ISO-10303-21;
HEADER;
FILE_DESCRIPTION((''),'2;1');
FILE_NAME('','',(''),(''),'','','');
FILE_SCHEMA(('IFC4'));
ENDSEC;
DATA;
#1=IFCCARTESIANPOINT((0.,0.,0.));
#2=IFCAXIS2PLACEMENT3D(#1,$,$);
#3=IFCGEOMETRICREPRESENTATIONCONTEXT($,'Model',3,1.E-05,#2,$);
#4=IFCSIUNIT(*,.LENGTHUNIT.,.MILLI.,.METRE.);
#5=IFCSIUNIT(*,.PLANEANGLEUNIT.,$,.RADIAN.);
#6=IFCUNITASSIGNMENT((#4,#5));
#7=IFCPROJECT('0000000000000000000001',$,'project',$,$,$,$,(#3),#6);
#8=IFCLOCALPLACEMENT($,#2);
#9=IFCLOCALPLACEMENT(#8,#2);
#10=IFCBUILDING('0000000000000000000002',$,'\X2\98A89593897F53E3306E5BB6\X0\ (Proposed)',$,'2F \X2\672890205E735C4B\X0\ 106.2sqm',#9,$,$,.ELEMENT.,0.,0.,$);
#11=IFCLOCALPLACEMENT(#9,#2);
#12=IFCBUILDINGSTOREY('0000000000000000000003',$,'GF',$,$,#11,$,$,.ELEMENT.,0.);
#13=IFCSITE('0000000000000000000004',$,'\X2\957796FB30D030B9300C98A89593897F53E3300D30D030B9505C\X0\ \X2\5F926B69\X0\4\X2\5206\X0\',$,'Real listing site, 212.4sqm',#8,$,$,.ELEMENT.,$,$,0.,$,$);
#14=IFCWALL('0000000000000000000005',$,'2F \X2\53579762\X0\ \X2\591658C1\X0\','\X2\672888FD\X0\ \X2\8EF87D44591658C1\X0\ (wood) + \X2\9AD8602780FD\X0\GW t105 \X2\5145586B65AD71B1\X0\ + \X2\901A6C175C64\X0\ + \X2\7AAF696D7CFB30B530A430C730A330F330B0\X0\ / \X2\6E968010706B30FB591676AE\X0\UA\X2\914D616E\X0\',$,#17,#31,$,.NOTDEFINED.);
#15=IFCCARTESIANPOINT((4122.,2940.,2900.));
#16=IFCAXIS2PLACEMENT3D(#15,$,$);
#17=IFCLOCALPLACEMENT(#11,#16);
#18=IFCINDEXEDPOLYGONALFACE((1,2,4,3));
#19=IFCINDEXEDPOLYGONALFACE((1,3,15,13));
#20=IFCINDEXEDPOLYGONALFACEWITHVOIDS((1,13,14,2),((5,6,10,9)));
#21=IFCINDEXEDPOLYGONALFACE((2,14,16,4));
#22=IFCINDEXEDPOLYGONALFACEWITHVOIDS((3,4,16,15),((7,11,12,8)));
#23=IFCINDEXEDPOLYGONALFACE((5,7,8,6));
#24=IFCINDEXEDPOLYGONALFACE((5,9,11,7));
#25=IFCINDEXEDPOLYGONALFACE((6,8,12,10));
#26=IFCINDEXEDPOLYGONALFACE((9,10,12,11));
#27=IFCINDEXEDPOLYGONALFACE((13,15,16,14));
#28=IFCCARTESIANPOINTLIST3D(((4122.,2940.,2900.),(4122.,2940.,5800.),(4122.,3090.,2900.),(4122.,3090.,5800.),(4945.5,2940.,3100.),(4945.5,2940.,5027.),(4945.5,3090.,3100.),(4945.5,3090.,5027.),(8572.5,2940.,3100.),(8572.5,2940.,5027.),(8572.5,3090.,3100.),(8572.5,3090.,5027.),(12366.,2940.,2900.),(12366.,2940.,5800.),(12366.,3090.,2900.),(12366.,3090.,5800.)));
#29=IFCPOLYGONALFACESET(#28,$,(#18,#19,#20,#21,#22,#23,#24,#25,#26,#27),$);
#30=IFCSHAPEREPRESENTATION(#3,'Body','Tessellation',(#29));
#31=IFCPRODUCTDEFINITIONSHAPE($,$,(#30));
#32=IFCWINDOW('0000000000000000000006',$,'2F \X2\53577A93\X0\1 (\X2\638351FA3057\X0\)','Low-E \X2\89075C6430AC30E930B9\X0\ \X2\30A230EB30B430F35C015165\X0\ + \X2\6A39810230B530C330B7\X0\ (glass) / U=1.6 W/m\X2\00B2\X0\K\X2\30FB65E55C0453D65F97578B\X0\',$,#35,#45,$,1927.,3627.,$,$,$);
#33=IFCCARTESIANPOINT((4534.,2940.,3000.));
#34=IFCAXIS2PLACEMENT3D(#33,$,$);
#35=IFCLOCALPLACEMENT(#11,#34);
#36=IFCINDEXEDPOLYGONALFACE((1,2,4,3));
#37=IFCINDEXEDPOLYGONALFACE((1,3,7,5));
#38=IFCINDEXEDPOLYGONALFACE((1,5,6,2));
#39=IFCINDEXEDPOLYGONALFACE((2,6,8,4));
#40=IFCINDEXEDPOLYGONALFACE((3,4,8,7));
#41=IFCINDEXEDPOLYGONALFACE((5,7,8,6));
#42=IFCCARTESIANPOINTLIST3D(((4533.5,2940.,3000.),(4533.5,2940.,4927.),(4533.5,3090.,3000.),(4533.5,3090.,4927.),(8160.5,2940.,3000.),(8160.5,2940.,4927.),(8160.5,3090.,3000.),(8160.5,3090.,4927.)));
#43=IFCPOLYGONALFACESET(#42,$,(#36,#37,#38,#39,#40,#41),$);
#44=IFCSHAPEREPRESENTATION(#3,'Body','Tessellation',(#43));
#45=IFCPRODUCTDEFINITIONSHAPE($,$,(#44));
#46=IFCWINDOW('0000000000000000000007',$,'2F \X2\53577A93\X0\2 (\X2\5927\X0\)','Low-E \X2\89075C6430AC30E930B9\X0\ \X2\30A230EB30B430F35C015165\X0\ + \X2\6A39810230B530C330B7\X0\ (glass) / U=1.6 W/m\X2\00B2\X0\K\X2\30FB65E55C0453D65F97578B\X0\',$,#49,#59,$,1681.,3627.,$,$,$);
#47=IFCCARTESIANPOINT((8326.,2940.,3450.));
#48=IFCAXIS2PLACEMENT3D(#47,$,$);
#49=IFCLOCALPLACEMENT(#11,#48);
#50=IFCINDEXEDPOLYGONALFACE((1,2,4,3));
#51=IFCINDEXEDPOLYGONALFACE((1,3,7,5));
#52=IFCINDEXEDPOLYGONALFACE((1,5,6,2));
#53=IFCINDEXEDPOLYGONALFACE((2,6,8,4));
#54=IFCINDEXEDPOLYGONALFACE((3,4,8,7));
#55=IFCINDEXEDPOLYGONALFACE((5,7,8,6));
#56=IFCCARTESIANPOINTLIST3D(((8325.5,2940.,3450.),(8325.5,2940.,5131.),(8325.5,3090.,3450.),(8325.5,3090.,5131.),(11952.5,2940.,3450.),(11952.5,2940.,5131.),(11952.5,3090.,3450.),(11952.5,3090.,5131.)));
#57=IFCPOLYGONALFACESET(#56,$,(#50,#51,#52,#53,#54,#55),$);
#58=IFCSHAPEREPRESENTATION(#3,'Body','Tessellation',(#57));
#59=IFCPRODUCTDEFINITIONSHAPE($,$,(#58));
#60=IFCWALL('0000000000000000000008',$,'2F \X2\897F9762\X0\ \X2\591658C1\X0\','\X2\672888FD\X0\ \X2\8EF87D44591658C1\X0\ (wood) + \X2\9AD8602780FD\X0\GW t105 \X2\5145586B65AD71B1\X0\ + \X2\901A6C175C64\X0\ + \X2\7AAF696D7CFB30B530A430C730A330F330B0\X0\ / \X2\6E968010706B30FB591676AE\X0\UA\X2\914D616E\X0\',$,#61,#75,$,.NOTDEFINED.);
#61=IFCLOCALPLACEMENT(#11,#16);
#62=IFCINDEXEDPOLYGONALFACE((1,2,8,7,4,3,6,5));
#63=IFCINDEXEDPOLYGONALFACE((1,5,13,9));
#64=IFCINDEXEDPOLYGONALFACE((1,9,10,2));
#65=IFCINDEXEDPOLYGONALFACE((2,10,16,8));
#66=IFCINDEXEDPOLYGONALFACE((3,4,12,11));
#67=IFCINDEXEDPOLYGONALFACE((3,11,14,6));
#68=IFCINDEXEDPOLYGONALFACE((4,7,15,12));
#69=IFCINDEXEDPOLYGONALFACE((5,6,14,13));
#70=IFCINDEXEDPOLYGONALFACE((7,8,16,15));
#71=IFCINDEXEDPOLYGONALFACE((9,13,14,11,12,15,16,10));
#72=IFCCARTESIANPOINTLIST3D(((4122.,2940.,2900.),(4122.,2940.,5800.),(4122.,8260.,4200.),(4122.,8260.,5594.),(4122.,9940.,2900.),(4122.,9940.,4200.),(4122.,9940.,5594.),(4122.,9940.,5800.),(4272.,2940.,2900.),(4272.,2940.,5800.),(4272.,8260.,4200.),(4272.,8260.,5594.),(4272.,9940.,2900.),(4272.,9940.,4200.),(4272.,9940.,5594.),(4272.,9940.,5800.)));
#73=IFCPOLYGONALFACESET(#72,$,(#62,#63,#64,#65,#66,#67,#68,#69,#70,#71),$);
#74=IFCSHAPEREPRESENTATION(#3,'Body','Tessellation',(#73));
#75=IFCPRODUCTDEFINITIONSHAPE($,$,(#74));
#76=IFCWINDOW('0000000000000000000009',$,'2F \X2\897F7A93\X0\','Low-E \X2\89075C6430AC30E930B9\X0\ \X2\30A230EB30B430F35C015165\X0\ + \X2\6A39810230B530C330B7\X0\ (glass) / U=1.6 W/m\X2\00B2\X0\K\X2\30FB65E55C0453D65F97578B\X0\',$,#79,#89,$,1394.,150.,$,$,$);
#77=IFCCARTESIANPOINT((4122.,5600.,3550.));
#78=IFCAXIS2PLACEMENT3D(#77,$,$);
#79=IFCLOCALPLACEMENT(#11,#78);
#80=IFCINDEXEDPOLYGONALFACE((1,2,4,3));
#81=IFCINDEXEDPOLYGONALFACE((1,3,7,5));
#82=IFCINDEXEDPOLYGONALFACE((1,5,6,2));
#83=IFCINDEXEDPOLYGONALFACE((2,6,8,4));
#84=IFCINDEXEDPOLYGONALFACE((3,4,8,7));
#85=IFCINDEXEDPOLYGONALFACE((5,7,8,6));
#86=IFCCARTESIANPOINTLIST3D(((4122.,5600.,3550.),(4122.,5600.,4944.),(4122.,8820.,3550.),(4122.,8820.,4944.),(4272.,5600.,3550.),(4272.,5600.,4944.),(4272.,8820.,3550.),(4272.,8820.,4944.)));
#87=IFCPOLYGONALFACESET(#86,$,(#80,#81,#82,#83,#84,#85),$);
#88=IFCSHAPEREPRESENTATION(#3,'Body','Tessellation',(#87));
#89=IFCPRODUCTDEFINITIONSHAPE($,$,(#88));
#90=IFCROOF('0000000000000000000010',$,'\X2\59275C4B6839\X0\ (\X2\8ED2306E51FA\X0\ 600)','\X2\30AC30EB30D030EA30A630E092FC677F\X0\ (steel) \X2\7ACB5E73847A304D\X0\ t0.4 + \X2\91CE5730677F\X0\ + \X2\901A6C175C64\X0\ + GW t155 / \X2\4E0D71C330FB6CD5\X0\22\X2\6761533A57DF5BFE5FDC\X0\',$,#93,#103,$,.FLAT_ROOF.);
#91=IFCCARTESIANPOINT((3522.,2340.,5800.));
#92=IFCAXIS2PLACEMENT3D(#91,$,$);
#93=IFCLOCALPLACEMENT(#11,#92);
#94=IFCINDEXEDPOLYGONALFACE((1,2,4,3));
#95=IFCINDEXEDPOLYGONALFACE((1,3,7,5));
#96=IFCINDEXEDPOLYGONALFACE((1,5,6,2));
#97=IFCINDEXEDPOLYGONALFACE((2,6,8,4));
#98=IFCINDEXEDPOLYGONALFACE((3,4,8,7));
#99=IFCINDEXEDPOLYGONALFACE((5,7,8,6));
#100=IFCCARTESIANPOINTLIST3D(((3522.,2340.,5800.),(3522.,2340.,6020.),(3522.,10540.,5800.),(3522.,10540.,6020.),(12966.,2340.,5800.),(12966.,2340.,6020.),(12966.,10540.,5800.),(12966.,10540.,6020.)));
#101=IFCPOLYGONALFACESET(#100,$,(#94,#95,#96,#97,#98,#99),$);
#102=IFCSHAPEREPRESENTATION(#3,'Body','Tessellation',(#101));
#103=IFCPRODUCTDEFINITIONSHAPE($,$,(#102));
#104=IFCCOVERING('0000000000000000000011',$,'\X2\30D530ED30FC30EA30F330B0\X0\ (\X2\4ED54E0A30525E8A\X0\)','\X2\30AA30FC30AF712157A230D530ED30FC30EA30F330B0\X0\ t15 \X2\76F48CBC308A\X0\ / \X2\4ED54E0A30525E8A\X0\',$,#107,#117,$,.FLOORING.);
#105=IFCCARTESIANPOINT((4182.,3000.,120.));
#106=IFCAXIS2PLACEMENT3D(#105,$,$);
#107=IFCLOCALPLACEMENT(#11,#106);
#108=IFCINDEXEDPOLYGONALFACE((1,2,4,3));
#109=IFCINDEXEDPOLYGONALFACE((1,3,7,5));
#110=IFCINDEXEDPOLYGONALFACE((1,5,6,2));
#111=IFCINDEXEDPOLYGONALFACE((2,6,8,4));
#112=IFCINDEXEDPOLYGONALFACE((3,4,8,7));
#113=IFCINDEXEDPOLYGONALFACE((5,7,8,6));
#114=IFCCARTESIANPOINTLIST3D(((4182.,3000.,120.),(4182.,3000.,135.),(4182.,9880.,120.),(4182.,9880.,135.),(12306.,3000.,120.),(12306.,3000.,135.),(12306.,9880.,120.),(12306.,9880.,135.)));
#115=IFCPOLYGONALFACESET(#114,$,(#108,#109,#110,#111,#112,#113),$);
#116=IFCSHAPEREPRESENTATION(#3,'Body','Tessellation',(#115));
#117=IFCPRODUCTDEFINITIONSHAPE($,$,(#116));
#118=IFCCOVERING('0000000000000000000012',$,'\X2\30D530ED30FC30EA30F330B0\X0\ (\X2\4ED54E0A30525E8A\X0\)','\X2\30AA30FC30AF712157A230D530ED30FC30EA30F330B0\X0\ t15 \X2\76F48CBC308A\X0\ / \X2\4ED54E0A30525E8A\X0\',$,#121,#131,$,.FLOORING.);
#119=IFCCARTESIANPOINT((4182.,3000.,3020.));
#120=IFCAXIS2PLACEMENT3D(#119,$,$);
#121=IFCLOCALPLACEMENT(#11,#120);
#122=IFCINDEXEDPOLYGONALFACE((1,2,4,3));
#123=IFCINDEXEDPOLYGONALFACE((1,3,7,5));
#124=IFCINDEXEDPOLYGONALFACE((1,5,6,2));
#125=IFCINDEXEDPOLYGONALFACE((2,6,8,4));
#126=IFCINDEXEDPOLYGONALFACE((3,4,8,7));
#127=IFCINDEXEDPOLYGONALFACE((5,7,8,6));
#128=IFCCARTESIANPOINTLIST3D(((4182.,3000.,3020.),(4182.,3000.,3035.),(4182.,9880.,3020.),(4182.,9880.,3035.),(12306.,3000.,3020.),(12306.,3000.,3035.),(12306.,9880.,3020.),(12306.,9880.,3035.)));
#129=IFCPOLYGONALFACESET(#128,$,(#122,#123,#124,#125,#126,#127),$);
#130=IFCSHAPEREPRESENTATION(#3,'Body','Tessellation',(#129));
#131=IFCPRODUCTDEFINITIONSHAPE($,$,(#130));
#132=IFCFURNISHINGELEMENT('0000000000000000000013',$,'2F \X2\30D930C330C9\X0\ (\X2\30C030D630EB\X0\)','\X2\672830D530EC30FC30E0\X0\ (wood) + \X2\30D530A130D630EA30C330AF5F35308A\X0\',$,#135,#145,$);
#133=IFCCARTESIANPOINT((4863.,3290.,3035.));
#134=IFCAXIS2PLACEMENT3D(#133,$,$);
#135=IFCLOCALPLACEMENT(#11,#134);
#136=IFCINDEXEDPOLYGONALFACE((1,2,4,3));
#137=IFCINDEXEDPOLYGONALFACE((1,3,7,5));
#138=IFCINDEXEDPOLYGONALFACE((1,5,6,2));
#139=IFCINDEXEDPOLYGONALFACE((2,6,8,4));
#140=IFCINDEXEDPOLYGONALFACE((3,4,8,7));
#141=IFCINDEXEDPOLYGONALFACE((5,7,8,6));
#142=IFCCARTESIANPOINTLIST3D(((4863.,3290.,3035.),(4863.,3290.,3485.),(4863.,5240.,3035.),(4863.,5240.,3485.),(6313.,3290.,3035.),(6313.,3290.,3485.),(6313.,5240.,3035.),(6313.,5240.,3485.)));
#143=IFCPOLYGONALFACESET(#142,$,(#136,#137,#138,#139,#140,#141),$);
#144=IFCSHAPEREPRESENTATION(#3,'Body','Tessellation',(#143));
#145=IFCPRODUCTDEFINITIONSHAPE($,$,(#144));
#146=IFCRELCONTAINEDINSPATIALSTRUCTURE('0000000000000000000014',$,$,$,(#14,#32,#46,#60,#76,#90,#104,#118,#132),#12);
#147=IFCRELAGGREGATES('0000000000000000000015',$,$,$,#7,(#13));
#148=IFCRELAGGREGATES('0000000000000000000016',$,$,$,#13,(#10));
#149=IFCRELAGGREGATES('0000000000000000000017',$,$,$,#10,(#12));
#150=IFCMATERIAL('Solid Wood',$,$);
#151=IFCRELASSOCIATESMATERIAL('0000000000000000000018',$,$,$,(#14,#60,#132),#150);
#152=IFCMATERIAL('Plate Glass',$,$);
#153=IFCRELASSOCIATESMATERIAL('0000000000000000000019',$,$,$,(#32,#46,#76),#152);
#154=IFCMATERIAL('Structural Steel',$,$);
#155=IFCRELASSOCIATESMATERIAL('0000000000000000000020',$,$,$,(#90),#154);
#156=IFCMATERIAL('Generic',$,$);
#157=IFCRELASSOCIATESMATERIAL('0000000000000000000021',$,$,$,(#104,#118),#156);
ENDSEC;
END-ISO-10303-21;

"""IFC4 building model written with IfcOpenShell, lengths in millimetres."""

from ifc_helpers import new_model, si_unit, frame, frame_2d, origin, place, context, project, spatial, rectangle, extrude, material, element, fill, save


model = new_model("IFC4")

# Units and contexts
model_context = context("Model", 3, precision=1e-05, world=origin())
ifc_project = project(units=[si_unit("LENGTHUNIT", "METRE", prefix="MILLI"), si_unit("PLANEANGLEUNIT", "RADIAN")], contexts=[model_context])

# Site, building, storey
site_placement = place(None, origin())
site = spatial("IfcSite", under=ifc_project, at=site_placement, Name="長電バス「風間西口」バス停 徒歩4分", ObjectType="Real listing site, 212.4sqm", CompositionType="ELEMENT", RefElevation=0.0)
building_placement = place(site_placement, origin())
building = spatial("IfcBuilding", under=site, at=building_placement, Name="風間西口の家 (Proposed)", ObjectType="2F 木造平屋 106.2sqm", CompositionType="ELEMENT", ElevationOfRefHeight=0.0, ElevationOfTerrain=0.0)
storey_placement = place(building_placement, origin())
storey = spatial("IfcBuildingStorey", under=building, at=storey_placement, Name="GF", CompositionType="ELEMENT", Elevation=0.0)

# Shared definitions
ifc_material_1 = material(Name="Solid Wood")

# Shared definitions
ifc_material_2 = material(Name="Plate Glass")

# Wall, openings, windows
wall_1_placement = place(storey_placement, frame((4122.0, 2940.0, 2900.0)))
wall_1 = element("IfcWall", 1, at=wall_1_placement, inside=storey, material=ifc_material_1, Name="2F 南面 外壁", Description="木製 軸組外壁 (wood) + 高性能GW t105 充填断熱 + 通気層 + 窯業系サイディング / 準耐火・外皮UA配慮", PredefinedType="NOTDEFINED", context=model_context, shape_type="SweptSolid", body=[
    extrude(rectangle(XDim=8244.0, YDim=150.0, at=frame_2d((4122.0, 75.0))), frame((4122.0, 2940.0, 2900.0)), (0.0, 0.0, 1.0), 2900.0),
])
opening_1_placement = place(storey_placement, frame((4534.0, 2940.0, 3000.0)))
opening_1 = element("IfcOpeningElement", 2, at=opening_1_placement, cuts=wall_1, PredefinedType="NOTDEFINED", context=model_context, shape_type="SweptSolid", body=[
    extrude(rectangle(XDim=3627.0, YDim=150.0, at=frame_2d((1813.0, 75.0))), frame((4534.0, 2940.0, 3000.0)), (0.0, 0.0, 1.0), 1927.0),
])
opening_2_placement = place(storey_placement, frame((8326.0, 2940.0, 3450.0)))
opening_2 = element("IfcOpeningElement", 3, at=opening_2_placement, cuts=wall_1, PredefinedType="NOTDEFINED", context=model_context, shape_type="SweptSolid", body=[
    extrude(rectangle(XDim=3627.0, YDim=150.0, at=frame_2d((1813.0, 75.0))), frame((8326.0, 2940.0, 3450.0)), (0.0, 0.0, 1.0), 1681.0),
])
window_1_placement = place(storey_placement, frame((4534.0, 2940.0, 3000.0)))
window_1 = element("IfcWindow", 4, at=window_1_placement, inside=storey, material=ifc_material_2, Name="2F 南窓1 (掃出し)", Description="Low-E 複層ガラス アルゴン封入 + 樹脂サッシ (glass) / U=1.6 W/m²K・日射取得型", OverallHeight=1927.0, OverallWidth=3627.0, context=model_context, shape_type="SweptSolid", body=[
    extrude(rectangle(XDim=3627.0, YDim=150.0, at=frame_2d((1813.0, 75.0))), frame((4534.0, 2940.0, 3000.0)), (0.0, 0.0, 1.0), 1927.0),
])
fill(opening_1, window_1)
window_2_placement = place(storey_placement, frame((8326.0, 2940.0, 3450.0)))
window_2 = element("IfcWindow", 5, at=window_2_placement, inside=storey, material=ifc_material_2, Name="2F 南窓2 (大)", Description="Low-E 複層ガラス アルゴン封入 + 樹脂サッシ (glass) / U=1.6 W/m²K・日射取得型", OverallHeight=1681.0, OverallWidth=3627.0, context=model_context, shape_type="SweptSolid", body=[
    extrude(rectangle(XDim=3627.0, YDim=150.0, at=frame_2d((1813.0, 75.0))), frame((8326.0, 2940.0, 3450.0)), (0.0, 0.0, 1.0), 1681.0),
])
fill(opening_2, window_2)

# Wall, opening, window
wall_2_placement = place(storey_placement, frame((4122.0, 2940.0, 2900.0)))
wall_2 = element("IfcWall", 6, at=wall_2_placement, inside=storey, material=ifc_material_1, Name="2F 西面 外壁", Description="木製 軸組外壁 (wood) + 高性能GW t105 充填断熱 + 通気層 + 窯業系サイディング / 準耐火・外皮UA配慮", PredefinedType="NOTDEFINED", context=model_context, shape_type="SweptSolid", body=[
    extrude(rectangle(XDim=150.0, YDim=7000.0, at=frame_2d((75.0, 3500.0))), frame((4122.0, 2940.0, 2900.0)), (0.0, 0.0, 1.0), 2900.0),
])
opening_3_placement = place(storey_placement, frame((4122.0, 5600.0, 3550.0)))
opening_3 = element("IfcOpeningElement", 7, at=opening_3_placement, cuts=wall_2, PredefinedType="NOTDEFINED", context=model_context, shape_type="SweptSolid", body=[
    extrude(rectangle(XDim=150.0, YDim=3220.0, at=frame_2d((75.0, 1610.0))), frame((4122.0, 5600.0, 3550.0)), (0.0, 0.0, 1.0), 1394.0),
])
window_3_placement = place(storey_placement, frame((4122.0, 5600.0, 3550.0)))
window_3 = element("IfcWindow", 8, at=window_3_placement, inside=storey, material=ifc_material_2, Name="2F 西窓", Description="Low-E 複層ガラス アルゴン封入 + 樹脂サッシ (glass) / U=1.6 W/m²K・日射取得型", OverallHeight=1394.0, OverallWidth=150.0, context=model_context, shape_type="SweptSolid", body=[
    extrude(rectangle(XDim=150.0, YDim=3220.0, at=frame_2d((75.0, 1610.0))), frame((4122.0, 5600.0, 3550.0)), (0.0, 0.0, 1.0), 1394.0),
])
fill(opening_3, window_3)

# Roof
ifc_material_3 = material(Name="Structural Steel")
roof_placement = place(storey_placement, frame((3522.0, 2340.0, 5800.0)))
element("IfcRoof", 9, at=roof_placement, inside=storey, material=ifc_material_3, Name="大屋根 (軒の出 600)", Description="ガルバリウム鋼板 (steel) 立平葺き t0.4 + 野地板 + 通気層 + GW t155 / 不燃・法22条区域対応", PredefinedType="FLAT_ROOF", context=model_context, shape_type="SweptSolid", body=[
    extrude(rectangle(XDim=9444.0, YDim=8200.0, at=frame_2d((4722.0, 4100.0))), frame((3522.0, 2340.0, 5800.0)), (0.0, 0.0, 1.0), 220.0),
])

# Coverings
ifc_material_4 = material(Name="Generic")
covering_1_placement = place(storey_placement, frame((4182.0, 3000.0, 120.0)))
element("IfcCovering", 10, at=covering_1_placement, inside=storey, material=ifc_material_4, Name="フローリング (仕上げ床)", Description="オーク無垢フローリング t15 直貼り / 仕上げ床", PredefinedType="FLOORING", context=model_context, shape_type="SweptSolid", body=[
    extrude(rectangle(XDim=8124.0, YDim=6880.0, at=frame_2d((4062.0, 3440.0))), frame((4182.0, 3000.0, 120.0)), (0.0, 0.0, 1.0), 15.0),
])
covering_2_placement = place(storey_placement, frame((4182.0, 3000.0, 3020.0)))
element("IfcCovering", 11, at=covering_2_placement, inside=storey, material=ifc_material_4, Name="フローリング (仕上げ床)", Description="オーク無垢フローリング t15 直貼り / 仕上げ床", PredefinedType="FLOORING", context=model_context, shape_type="SweptSolid", body=[
    extrude(rectangle(XDim=8124.0, YDim=6880.0, at=frame_2d((4062.0, 3440.0))), frame((4182.0, 3000.0, 3020.0)), (0.0, 0.0, 1.0), 15.0),
])

# Furnishing element
furnishing_placement = place(storey_placement, frame((4863.0, 3290.0, 3035.0)))
element("IfcFurnishingElement", 12, at=furnishing_placement, inside=storey, material=ifc_material_1, Name="2F ベッド (ダブル)", Description="木フレーム (wood) + ファブリック張り", context=model_context, shape_type="SweptSolid", body=[
    extrude(rectangle(XDim=1450.0, YDim=1950.0, at=frame_2d((725.0, 975.0))), frame((4863.0, 3290.0, 3035.0)), (0.0, 0.0, 1.0), 450.0),
])

save(model, "model.ifc")
